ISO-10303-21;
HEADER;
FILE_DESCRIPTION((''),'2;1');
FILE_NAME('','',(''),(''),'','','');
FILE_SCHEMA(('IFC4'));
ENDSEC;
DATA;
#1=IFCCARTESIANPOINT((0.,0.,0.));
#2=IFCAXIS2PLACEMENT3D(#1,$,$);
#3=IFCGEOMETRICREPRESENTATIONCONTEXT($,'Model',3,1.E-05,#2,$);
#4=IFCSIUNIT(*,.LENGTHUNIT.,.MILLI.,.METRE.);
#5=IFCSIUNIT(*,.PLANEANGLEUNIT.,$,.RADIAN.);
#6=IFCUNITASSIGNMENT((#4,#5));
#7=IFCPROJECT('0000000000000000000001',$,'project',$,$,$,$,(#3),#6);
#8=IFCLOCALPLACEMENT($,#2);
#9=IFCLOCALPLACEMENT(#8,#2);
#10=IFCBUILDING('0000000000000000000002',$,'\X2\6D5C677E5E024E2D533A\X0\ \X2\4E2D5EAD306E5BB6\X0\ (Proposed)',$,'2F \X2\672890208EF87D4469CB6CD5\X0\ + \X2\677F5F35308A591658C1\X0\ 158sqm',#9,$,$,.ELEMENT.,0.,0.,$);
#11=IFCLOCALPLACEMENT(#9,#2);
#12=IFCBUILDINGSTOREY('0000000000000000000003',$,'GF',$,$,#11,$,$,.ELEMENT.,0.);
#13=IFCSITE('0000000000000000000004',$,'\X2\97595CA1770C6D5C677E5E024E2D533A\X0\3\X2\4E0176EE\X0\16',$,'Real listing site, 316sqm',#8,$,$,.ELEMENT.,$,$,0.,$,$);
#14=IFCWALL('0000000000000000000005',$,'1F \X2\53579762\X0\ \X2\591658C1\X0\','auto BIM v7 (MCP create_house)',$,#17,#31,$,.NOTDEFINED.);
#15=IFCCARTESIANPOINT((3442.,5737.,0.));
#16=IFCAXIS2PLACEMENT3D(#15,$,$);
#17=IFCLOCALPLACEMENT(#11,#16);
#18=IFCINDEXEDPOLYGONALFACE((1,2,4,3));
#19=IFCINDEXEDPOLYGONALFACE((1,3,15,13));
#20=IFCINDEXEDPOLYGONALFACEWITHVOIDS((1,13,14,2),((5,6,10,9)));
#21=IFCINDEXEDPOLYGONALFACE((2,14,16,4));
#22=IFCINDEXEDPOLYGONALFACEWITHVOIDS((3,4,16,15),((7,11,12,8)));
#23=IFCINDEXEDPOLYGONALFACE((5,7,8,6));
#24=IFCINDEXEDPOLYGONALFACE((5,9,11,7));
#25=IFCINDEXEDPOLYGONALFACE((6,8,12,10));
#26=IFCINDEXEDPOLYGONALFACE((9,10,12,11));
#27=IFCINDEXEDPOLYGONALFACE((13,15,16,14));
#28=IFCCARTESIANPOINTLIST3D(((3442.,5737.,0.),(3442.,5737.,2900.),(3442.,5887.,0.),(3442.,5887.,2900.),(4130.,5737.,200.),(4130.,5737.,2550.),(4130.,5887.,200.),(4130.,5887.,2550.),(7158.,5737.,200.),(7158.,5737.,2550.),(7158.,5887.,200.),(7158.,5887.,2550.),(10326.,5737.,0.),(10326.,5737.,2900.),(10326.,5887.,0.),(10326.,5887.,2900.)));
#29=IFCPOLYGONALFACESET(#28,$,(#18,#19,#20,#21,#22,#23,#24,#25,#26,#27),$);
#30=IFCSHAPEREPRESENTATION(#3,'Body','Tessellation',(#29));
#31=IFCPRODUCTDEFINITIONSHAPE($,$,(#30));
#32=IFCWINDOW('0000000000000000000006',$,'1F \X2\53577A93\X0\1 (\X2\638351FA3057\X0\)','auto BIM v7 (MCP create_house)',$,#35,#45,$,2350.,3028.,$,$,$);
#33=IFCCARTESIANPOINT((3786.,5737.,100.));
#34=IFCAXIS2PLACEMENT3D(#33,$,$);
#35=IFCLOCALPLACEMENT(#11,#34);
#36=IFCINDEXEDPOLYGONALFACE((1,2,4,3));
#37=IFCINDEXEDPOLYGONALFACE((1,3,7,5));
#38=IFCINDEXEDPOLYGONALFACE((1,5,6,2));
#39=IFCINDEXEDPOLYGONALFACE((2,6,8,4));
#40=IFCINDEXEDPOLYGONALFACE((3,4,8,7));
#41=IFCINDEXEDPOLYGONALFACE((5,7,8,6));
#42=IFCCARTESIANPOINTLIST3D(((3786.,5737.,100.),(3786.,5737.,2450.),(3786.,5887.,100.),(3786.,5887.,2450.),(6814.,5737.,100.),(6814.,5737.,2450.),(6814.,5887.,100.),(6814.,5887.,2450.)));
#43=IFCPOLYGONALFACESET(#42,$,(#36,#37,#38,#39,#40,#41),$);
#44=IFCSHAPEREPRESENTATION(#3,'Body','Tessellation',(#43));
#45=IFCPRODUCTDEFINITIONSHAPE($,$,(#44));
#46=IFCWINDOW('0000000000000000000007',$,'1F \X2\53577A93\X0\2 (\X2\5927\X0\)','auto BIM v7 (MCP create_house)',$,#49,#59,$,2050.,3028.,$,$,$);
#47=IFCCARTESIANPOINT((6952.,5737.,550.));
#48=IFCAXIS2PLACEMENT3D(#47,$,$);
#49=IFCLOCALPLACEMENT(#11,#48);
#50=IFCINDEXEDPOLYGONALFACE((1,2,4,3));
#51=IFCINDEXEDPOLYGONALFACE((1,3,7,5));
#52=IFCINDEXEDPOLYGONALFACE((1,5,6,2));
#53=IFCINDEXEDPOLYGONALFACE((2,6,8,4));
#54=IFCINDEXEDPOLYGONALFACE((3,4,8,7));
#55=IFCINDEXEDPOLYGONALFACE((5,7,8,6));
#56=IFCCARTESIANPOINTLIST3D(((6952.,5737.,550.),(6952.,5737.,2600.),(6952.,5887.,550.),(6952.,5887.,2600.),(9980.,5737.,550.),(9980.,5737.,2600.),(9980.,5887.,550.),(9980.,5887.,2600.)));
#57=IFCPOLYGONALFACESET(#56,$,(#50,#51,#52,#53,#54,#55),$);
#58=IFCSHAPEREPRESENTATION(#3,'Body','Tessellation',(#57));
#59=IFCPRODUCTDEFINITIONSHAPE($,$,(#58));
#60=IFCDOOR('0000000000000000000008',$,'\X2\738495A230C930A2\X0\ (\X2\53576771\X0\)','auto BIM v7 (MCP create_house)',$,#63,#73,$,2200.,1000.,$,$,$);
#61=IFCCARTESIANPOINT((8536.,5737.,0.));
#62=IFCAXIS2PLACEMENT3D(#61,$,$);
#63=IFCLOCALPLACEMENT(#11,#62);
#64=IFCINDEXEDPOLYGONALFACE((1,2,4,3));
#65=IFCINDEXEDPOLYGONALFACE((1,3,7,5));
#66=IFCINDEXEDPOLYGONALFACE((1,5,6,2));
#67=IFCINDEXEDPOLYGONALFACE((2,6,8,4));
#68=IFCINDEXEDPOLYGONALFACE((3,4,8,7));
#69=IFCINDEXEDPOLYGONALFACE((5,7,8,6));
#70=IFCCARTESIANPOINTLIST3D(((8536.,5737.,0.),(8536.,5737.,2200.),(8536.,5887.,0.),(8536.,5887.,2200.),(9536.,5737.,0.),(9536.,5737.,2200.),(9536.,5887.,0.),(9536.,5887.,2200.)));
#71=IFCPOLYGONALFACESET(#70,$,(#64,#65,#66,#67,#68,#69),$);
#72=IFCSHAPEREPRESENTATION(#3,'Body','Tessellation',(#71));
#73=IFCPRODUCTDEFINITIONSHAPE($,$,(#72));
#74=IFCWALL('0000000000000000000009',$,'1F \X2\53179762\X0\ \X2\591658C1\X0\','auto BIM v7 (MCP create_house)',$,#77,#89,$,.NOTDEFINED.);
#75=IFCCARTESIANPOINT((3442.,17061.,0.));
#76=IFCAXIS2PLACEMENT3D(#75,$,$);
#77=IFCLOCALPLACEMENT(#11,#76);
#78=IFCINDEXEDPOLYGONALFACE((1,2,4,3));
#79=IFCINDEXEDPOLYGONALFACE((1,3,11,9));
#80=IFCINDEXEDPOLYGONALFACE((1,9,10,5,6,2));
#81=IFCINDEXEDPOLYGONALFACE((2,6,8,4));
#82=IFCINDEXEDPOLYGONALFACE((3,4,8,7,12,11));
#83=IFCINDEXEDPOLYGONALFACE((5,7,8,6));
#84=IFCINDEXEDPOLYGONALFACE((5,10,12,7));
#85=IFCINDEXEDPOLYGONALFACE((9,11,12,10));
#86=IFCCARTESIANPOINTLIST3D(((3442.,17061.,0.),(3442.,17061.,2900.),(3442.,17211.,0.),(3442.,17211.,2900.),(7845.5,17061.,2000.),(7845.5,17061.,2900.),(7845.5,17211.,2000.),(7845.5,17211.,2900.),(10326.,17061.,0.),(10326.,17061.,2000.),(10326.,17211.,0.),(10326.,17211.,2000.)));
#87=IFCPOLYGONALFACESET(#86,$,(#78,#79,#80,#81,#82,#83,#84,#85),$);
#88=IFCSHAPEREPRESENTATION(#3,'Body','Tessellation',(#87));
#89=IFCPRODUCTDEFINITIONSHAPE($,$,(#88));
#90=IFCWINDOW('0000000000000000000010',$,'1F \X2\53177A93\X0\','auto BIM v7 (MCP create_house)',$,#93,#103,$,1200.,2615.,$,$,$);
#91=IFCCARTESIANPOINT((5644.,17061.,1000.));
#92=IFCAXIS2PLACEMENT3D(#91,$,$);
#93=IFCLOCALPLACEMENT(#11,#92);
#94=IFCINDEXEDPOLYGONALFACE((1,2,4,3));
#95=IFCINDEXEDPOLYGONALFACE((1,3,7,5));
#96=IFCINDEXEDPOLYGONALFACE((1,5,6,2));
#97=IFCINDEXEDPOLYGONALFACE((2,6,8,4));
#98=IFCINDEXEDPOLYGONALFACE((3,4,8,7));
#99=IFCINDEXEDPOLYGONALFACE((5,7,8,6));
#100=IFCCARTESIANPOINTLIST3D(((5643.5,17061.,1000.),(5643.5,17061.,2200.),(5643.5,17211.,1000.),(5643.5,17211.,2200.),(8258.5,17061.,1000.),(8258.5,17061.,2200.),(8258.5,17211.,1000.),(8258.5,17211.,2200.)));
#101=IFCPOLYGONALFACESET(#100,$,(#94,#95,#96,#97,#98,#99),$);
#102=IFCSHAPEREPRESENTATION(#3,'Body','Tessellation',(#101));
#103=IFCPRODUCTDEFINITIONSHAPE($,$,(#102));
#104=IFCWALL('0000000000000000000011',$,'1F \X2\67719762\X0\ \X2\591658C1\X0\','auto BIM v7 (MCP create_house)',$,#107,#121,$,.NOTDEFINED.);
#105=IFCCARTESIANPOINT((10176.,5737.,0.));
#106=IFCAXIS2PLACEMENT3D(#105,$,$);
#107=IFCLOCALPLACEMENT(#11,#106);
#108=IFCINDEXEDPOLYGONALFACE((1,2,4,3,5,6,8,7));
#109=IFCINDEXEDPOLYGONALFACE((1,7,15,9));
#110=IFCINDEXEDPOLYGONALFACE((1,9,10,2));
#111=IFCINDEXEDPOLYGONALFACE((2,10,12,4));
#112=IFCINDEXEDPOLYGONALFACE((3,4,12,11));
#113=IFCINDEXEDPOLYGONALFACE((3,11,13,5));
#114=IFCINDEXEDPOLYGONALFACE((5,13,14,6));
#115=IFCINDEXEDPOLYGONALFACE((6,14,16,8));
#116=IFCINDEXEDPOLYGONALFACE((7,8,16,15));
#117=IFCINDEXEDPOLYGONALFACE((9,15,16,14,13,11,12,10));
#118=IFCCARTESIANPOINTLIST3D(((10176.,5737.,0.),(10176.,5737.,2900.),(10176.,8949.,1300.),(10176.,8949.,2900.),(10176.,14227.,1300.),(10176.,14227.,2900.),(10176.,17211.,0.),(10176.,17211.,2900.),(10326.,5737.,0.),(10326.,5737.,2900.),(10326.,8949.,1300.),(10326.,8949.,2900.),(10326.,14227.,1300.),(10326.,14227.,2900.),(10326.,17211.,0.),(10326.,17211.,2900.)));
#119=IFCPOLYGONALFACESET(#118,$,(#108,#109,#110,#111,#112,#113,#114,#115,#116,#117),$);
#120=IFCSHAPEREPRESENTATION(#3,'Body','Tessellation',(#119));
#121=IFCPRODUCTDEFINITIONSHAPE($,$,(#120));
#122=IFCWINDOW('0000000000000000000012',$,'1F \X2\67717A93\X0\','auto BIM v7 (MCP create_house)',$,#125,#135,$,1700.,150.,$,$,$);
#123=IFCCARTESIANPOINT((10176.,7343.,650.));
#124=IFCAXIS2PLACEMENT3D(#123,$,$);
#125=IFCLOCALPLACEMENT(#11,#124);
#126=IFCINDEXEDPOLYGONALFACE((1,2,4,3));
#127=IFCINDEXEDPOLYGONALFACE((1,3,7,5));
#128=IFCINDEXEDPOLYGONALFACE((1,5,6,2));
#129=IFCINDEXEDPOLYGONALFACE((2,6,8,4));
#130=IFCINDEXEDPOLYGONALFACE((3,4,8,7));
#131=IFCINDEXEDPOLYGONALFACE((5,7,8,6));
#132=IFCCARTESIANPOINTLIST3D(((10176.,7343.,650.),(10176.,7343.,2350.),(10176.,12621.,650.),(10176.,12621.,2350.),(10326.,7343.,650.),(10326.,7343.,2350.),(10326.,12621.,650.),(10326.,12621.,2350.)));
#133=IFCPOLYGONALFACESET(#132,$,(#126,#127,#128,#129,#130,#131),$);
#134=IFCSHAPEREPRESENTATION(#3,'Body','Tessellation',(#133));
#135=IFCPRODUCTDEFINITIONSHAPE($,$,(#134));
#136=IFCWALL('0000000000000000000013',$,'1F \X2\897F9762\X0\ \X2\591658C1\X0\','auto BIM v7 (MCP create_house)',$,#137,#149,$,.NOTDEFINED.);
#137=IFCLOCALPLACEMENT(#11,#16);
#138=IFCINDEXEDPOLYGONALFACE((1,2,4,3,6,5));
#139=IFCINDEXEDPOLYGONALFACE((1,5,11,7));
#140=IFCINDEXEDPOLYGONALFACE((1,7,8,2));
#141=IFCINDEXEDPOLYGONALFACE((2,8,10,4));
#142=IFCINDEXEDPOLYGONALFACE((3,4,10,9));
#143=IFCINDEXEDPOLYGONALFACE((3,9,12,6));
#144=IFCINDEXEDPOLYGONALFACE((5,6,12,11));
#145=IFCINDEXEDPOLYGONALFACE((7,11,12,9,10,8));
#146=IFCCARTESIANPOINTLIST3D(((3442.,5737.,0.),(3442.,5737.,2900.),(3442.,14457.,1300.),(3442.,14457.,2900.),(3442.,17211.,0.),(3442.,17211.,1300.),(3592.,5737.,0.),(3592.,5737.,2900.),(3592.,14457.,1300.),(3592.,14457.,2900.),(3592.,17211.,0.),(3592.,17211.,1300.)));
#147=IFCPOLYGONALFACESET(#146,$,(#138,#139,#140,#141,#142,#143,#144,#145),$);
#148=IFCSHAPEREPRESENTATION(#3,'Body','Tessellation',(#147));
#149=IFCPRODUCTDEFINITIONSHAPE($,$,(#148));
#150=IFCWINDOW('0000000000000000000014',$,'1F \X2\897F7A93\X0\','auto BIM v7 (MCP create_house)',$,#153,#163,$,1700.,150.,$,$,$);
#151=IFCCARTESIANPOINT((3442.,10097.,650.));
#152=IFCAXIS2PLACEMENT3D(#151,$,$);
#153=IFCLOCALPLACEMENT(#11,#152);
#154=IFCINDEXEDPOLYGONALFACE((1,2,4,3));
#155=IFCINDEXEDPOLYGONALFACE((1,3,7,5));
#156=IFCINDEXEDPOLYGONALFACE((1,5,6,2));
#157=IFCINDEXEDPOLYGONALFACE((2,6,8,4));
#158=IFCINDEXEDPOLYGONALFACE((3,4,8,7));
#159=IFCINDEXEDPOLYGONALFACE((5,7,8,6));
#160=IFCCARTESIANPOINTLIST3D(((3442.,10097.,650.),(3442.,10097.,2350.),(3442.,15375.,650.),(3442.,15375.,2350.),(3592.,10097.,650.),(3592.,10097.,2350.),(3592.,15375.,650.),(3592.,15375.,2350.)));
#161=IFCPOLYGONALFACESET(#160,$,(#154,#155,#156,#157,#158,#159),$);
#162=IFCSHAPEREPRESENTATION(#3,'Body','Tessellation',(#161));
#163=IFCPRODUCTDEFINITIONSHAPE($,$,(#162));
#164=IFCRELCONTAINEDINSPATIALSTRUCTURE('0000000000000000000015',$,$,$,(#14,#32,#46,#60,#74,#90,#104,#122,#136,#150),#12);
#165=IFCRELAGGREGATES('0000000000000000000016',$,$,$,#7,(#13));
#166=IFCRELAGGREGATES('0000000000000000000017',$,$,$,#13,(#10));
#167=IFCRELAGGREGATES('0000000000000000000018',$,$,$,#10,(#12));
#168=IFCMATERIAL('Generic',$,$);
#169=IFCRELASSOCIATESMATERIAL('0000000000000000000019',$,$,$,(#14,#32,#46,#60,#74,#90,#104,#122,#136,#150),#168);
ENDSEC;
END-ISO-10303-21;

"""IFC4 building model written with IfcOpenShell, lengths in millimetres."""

from ifc_helpers import new_model, si_unit, frame, frame_2d, origin, place, context, project, spatial, rectangle, extrude, material, element, fill, save


model = new_model("IFC4")

# Units and contexts
model_context = context("Model", 3, precision=1e-05, world=origin())
ifc_project = project(units=[si_unit("LENGTHUNIT", "METRE", prefix="MILLI"), si_unit("PLANEANGLEUNIT", "RADIAN")], contexts=[model_context])

# Site, building, storey
site_placement = place(None, origin())
site = spatial("IfcSite", under=ifc_project, at=site_placement, Name="静岡県浜松市中区3丁目16", ObjectType="Real listing site, 316sqm", CompositionType="ELEMENT", RefElevation=0.0)
building_placement = place(site_placement, origin())
building = spatial("IfcBuilding", under=site, at=building_placement, Name="浜松市中区 中庭の家 (Proposed)", ObjectType="2F 木造軸組構法 + 板張り外壁 158sqm", CompositionType="ELEMENT", ElevationOfRefHeight=0.0, ElevationOfTerrain=0.0)
storey_placement = place(building_placement, origin())
storey = spatial("IfcBuildingStorey", under=building, at=storey_placement, Name="GF", CompositionType="ELEMENT", Elevation=0.0)

# Shared definitions
ifc_material = material(Name="Generic")

# Wall, openings, windows, door
wall_1_placement = place(storey_placement, frame((3442.0, 5737.0, 0.0)))
wall_1 = element("IfcWall", 1, at=wall_1_placement, inside=storey, material=ifc_material, Name="1F 南面 外壁", Description="auto BIM v7 (MCP create_house)", PredefinedType="NOTDEFINED", context=model_context, shape_type="SweptSolid", body=[
    extrude(rectangle(XDim=6884.0, YDim=150.0, at=frame_2d((3442.0, 75.0))), frame((3442.0, 5737.0, 0.0)), (0.0, 0.0, 1.0), 2900.0),
])
opening_1_placement = place(storey_placement, frame((3786.0, 5737.0, 100.0)))
opening_1 = element("IfcOpeningElement", 2, at=opening_1_placement, cuts=wall_1, PredefinedType="NOTDEFINED", context=model_context, shape_type="SweptSolid", body=[
    extrude(rectangle(XDim=3028.0, YDim=150.0, at=frame_2d((1514.0, 75.0))), frame((3786.0, 5737.0, 100.0)), (0.0, 0.0, 1.0), 2350.0),
])
opening_2_placement = place(storey_placement, frame((6952.0, 5737.0, 550.0)))
opening_2 = element("IfcOpeningElement", 3, at=opening_2_placement, cuts=wall_1, PredefinedType="NOTDEFINED", context=model_context, shape_type="SweptSolid", body=[
    extrude(rectangle(XDim=3028.0, YDim=150.0, at=frame_2d((1514.0, 75.0))), frame((6952.0, 5737.0, 550.0)), (0.0, 0.0, 1.0), 2050.0),
])
opening_3_placement = place(storey_placement, frame((8536.0, 5737.0, 0.0)))
opening_3 = element("IfcOpeningElement", 4, at=opening_3_placement, cuts=wall_1, PredefinedType="NOTDEFINED", context=model_context, shape_type="SweptSolid", body=[
    extrude(rectangle(XDim=1000.0, YDim=150.0, at=frame_2d((500.0, 75.0))), frame((8536.0, 5737.0, 0.0)), (0.0, 0.0, 1.0), 2200.0),
])
window_1_placement = place(storey_placement, frame((3786.0, 5737.0, 100.0)))
window_1 = element("IfcWindow", 5, at=window_1_placement, inside=storey, material=ifc_material, Name="1F 南窓1 (掃出し)", Description="auto BIM v7 (MCP create_house)", OverallHeight=2350.0, OverallWidth=3028.0, context=model_context, shape_type="SweptSolid", body=[
    extrude(rectangle(XDim=3028.0, YDim=150.0, at=frame_2d((1514.0, 75.0))), frame((3786.0, 5737.0, 100.0)), (0.0, 0.0, 1.0), 2350.0),
])
fill(opening_1, window_1)
window_2_placement = place(storey_placement, frame((6952.0, 5737.0, 550.0)))
window_2 = element("IfcWindow", 6, at=window_2_placement, inside=storey, material=ifc_material, Name="1F 南窓2 (大)", Description="auto BIM v7 (MCP create_house)", OverallHeight=2050.0, OverallWidth=3028.0, context=model_context, shape_type="SweptSolid", body=[
    extrude(rectangle(XDim=3028.0, YDim=150.0, at=frame_2d((1514.0, 75.0))), frame((6952.0, 5737.0, 550.0)), (0.0, 0.0, 1.0), 2050.0),
])
fill(opening_2, window_2)
door_placement = place(storey_placement, frame((8536.0, 5737.0, 0.0)))
door = element("IfcDoor", 7, at=door_placement, inside=storey, material=ifc_material, Name="玄関ドア (南東)", Description="auto BIM v7 (MCP create_house)", OverallHeight=2200.0, OverallWidth=1000.0, context=model_context, shape_type="SweptSolid", body=[
    extrude(rectangle(XDim=1000.0, YDim=150.0, at=frame_2d((500.0, 75.0))), frame((8536.0, 5737.0, 0.0)), (0.0, 0.0, 1.0), 2200.0),
])
fill(opening_3, door)

# Walls, openings, windows
wall_2_placement = place(storey_placement, frame((3442.0, 17061.0, 0.0)))
wall_2 = element("IfcWall", 8, at=wall_2_placement, inside=storey, material=ifc_material, Name="1F 北面 外壁", Description="auto BIM v7 (MCP create_house)", PredefinedType="NOTDEFINED", context=model_context, shape_type="SweptSolid", body=[
    extrude(rectangle(XDim=6884.0, YDim=150.0, at=frame_2d((3442.0, 75.0))), frame((3442.0, 17061.0, 0.0)), (0.0, 0.0, 1.0), 2900.0),
])
opening_4_placement = place(storey_placement, frame((5644.0, 17061.0, 1000.0)))
opening_4 = element("IfcOpeningElement", 9, at=opening_4_placement, cuts=wall_2, PredefinedType="NOTDEFINED", context=model_context, shape_type="SweptSolid", body=[
    extrude(rectangle(XDim=2615.0, YDim=150.0, at=frame_2d((1307.0, 75.0))), frame((5644.0, 17061.0, 1000.0)), (0.0, 0.0, 1.0), 1200.0),
])
window_3_placement = place(storey_placement, frame((5644.0, 17061.0, 1000.0)))
window_3 = element("IfcWindow", 10, at=window_3_placement, inside=storey, material=ifc_material, Name="1F 北窓", Description="auto BIM v7 (MCP create_house)", OverallHeight=1200.0, OverallWidth=2615.0, context=model_context, shape_type="SweptSolid", body=[
    extrude(rectangle(XDim=2615.0, YDim=150.0, at=frame_2d((1307.0, 75.0))), frame((5644.0, 17061.0, 1000.0)), (0.0, 0.0, 1.0), 1200.0),
])
fill(opening_4, window_3)
wall_3_placement = place(storey_placement, frame((10176.0, 5737.0, 0.0)))
wall_3 = element("IfcWall", 11, at=wall_3_placement, inside=storey, material=ifc_material, Name="1F 東面 外壁", Description="auto BIM v7 (MCP create_house)", PredefinedType="NOTDEFINED", context=model_context, shape_type="SweptSolid", body=[
    extrude(rectangle(XDim=150.0, YDim=11474.0, at=frame_2d((75.0, 5737.0))), frame((10176.0, 5737.0, 0.0)), (0.0, 0.0, 1.0), 2900.0),
])
opening_5_placement = place(storey_placement, frame((10176.0, 7343.0, 650.0)))
opening_5 = element("IfcOpeningElement", 12, at=opening_5_placement, cuts=wall_3, PredefinedType="NOTDEFINED", context=model_context, shape_type="SweptSolid", body=[
    extrude(rectangle(XDim=150.0, YDim=5278.0, at=frame_2d((75.0, 2639.0))), frame((10176.0, 7343.0, 650.0)), (0.0, 0.0, 1.0), 1700.0),
])
window_4_placement = place(storey_placement, frame((10176.0, 7343.0, 650.0)))
window_4 = element("IfcWindow", 13, at=window_4_placement, inside=storey, material=ifc_material, Name="1F 東窓", Description="auto BIM v7 (MCP create_house)", OverallHeight=1700.0, OverallWidth=150.0, context=model_context, shape_type="SweptSolid", body=[
    extrude(rectangle(XDim=150.0, YDim=5278.0, at=frame_2d((75.0, 2639.0))), frame((10176.0, 7343.0, 650.0)), (0.0, 0.0, 1.0), 1700.0),
])
fill(opening_5, window_4)
wall_4_placement = place(storey_placement, frame((3442.0, 5737.0, 0.0)))
wall_4 = element("IfcWall", 14, at=wall_4_placement, inside=storey, material=ifc_material, Name="1F 西面 外壁", Description="auto BIM v7 (MCP create_house)", PredefinedType="NOTDEFINED", context=model_context, shape_type="SweptSolid", body=[
    extrude(rectangle(XDim=150.0, YDim=11474.0, at=frame_2d((75.0, 5737.0))), frame((3442.0, 5737.0, 0.0)), (0.0, 0.0, 1.0), 2900.0),
])
opening_6_placement = place(storey_placement, frame((3442.0, 10097.0, 650.0)))
opening_6 = element("IfcOpeningElement", 15, at=opening_6_placement, cuts=wall_4, PredefinedType="NOTDEFINED", context=model_context, shape_type="SweptSolid", body=[
    extrude(rectangle(XDim=150.0, YDim=5278.0, at=frame_2d((75.0, 2639.0))), frame((3442.0, 10097.0, 650.0)), (0.0, 0.0, 1.0), 1700.0),
])
window_5_placement = place(storey_placement, frame((3442.0, 10097.0, 650.0)))
window_5 = element("IfcWindow", 16, at=window_5_placement, inside=storey, material=ifc_material, Name="1F 西窓", Description="auto BIM v7 (MCP create_house)", OverallHeight=1700.0, OverallWidth=150.0, context=model_context, shape_type="SweptSolid", body=[
    extrude(rectangle(XDim=150.0, YDim=5278.0, at=frame_2d((75.0, 2639.0))), frame((3442.0, 10097.0, 650.0)), (0.0, 0.0, 1.0), 1700.0),
])
fill(opening_6, window_5)

save(model, "model.ifc")
